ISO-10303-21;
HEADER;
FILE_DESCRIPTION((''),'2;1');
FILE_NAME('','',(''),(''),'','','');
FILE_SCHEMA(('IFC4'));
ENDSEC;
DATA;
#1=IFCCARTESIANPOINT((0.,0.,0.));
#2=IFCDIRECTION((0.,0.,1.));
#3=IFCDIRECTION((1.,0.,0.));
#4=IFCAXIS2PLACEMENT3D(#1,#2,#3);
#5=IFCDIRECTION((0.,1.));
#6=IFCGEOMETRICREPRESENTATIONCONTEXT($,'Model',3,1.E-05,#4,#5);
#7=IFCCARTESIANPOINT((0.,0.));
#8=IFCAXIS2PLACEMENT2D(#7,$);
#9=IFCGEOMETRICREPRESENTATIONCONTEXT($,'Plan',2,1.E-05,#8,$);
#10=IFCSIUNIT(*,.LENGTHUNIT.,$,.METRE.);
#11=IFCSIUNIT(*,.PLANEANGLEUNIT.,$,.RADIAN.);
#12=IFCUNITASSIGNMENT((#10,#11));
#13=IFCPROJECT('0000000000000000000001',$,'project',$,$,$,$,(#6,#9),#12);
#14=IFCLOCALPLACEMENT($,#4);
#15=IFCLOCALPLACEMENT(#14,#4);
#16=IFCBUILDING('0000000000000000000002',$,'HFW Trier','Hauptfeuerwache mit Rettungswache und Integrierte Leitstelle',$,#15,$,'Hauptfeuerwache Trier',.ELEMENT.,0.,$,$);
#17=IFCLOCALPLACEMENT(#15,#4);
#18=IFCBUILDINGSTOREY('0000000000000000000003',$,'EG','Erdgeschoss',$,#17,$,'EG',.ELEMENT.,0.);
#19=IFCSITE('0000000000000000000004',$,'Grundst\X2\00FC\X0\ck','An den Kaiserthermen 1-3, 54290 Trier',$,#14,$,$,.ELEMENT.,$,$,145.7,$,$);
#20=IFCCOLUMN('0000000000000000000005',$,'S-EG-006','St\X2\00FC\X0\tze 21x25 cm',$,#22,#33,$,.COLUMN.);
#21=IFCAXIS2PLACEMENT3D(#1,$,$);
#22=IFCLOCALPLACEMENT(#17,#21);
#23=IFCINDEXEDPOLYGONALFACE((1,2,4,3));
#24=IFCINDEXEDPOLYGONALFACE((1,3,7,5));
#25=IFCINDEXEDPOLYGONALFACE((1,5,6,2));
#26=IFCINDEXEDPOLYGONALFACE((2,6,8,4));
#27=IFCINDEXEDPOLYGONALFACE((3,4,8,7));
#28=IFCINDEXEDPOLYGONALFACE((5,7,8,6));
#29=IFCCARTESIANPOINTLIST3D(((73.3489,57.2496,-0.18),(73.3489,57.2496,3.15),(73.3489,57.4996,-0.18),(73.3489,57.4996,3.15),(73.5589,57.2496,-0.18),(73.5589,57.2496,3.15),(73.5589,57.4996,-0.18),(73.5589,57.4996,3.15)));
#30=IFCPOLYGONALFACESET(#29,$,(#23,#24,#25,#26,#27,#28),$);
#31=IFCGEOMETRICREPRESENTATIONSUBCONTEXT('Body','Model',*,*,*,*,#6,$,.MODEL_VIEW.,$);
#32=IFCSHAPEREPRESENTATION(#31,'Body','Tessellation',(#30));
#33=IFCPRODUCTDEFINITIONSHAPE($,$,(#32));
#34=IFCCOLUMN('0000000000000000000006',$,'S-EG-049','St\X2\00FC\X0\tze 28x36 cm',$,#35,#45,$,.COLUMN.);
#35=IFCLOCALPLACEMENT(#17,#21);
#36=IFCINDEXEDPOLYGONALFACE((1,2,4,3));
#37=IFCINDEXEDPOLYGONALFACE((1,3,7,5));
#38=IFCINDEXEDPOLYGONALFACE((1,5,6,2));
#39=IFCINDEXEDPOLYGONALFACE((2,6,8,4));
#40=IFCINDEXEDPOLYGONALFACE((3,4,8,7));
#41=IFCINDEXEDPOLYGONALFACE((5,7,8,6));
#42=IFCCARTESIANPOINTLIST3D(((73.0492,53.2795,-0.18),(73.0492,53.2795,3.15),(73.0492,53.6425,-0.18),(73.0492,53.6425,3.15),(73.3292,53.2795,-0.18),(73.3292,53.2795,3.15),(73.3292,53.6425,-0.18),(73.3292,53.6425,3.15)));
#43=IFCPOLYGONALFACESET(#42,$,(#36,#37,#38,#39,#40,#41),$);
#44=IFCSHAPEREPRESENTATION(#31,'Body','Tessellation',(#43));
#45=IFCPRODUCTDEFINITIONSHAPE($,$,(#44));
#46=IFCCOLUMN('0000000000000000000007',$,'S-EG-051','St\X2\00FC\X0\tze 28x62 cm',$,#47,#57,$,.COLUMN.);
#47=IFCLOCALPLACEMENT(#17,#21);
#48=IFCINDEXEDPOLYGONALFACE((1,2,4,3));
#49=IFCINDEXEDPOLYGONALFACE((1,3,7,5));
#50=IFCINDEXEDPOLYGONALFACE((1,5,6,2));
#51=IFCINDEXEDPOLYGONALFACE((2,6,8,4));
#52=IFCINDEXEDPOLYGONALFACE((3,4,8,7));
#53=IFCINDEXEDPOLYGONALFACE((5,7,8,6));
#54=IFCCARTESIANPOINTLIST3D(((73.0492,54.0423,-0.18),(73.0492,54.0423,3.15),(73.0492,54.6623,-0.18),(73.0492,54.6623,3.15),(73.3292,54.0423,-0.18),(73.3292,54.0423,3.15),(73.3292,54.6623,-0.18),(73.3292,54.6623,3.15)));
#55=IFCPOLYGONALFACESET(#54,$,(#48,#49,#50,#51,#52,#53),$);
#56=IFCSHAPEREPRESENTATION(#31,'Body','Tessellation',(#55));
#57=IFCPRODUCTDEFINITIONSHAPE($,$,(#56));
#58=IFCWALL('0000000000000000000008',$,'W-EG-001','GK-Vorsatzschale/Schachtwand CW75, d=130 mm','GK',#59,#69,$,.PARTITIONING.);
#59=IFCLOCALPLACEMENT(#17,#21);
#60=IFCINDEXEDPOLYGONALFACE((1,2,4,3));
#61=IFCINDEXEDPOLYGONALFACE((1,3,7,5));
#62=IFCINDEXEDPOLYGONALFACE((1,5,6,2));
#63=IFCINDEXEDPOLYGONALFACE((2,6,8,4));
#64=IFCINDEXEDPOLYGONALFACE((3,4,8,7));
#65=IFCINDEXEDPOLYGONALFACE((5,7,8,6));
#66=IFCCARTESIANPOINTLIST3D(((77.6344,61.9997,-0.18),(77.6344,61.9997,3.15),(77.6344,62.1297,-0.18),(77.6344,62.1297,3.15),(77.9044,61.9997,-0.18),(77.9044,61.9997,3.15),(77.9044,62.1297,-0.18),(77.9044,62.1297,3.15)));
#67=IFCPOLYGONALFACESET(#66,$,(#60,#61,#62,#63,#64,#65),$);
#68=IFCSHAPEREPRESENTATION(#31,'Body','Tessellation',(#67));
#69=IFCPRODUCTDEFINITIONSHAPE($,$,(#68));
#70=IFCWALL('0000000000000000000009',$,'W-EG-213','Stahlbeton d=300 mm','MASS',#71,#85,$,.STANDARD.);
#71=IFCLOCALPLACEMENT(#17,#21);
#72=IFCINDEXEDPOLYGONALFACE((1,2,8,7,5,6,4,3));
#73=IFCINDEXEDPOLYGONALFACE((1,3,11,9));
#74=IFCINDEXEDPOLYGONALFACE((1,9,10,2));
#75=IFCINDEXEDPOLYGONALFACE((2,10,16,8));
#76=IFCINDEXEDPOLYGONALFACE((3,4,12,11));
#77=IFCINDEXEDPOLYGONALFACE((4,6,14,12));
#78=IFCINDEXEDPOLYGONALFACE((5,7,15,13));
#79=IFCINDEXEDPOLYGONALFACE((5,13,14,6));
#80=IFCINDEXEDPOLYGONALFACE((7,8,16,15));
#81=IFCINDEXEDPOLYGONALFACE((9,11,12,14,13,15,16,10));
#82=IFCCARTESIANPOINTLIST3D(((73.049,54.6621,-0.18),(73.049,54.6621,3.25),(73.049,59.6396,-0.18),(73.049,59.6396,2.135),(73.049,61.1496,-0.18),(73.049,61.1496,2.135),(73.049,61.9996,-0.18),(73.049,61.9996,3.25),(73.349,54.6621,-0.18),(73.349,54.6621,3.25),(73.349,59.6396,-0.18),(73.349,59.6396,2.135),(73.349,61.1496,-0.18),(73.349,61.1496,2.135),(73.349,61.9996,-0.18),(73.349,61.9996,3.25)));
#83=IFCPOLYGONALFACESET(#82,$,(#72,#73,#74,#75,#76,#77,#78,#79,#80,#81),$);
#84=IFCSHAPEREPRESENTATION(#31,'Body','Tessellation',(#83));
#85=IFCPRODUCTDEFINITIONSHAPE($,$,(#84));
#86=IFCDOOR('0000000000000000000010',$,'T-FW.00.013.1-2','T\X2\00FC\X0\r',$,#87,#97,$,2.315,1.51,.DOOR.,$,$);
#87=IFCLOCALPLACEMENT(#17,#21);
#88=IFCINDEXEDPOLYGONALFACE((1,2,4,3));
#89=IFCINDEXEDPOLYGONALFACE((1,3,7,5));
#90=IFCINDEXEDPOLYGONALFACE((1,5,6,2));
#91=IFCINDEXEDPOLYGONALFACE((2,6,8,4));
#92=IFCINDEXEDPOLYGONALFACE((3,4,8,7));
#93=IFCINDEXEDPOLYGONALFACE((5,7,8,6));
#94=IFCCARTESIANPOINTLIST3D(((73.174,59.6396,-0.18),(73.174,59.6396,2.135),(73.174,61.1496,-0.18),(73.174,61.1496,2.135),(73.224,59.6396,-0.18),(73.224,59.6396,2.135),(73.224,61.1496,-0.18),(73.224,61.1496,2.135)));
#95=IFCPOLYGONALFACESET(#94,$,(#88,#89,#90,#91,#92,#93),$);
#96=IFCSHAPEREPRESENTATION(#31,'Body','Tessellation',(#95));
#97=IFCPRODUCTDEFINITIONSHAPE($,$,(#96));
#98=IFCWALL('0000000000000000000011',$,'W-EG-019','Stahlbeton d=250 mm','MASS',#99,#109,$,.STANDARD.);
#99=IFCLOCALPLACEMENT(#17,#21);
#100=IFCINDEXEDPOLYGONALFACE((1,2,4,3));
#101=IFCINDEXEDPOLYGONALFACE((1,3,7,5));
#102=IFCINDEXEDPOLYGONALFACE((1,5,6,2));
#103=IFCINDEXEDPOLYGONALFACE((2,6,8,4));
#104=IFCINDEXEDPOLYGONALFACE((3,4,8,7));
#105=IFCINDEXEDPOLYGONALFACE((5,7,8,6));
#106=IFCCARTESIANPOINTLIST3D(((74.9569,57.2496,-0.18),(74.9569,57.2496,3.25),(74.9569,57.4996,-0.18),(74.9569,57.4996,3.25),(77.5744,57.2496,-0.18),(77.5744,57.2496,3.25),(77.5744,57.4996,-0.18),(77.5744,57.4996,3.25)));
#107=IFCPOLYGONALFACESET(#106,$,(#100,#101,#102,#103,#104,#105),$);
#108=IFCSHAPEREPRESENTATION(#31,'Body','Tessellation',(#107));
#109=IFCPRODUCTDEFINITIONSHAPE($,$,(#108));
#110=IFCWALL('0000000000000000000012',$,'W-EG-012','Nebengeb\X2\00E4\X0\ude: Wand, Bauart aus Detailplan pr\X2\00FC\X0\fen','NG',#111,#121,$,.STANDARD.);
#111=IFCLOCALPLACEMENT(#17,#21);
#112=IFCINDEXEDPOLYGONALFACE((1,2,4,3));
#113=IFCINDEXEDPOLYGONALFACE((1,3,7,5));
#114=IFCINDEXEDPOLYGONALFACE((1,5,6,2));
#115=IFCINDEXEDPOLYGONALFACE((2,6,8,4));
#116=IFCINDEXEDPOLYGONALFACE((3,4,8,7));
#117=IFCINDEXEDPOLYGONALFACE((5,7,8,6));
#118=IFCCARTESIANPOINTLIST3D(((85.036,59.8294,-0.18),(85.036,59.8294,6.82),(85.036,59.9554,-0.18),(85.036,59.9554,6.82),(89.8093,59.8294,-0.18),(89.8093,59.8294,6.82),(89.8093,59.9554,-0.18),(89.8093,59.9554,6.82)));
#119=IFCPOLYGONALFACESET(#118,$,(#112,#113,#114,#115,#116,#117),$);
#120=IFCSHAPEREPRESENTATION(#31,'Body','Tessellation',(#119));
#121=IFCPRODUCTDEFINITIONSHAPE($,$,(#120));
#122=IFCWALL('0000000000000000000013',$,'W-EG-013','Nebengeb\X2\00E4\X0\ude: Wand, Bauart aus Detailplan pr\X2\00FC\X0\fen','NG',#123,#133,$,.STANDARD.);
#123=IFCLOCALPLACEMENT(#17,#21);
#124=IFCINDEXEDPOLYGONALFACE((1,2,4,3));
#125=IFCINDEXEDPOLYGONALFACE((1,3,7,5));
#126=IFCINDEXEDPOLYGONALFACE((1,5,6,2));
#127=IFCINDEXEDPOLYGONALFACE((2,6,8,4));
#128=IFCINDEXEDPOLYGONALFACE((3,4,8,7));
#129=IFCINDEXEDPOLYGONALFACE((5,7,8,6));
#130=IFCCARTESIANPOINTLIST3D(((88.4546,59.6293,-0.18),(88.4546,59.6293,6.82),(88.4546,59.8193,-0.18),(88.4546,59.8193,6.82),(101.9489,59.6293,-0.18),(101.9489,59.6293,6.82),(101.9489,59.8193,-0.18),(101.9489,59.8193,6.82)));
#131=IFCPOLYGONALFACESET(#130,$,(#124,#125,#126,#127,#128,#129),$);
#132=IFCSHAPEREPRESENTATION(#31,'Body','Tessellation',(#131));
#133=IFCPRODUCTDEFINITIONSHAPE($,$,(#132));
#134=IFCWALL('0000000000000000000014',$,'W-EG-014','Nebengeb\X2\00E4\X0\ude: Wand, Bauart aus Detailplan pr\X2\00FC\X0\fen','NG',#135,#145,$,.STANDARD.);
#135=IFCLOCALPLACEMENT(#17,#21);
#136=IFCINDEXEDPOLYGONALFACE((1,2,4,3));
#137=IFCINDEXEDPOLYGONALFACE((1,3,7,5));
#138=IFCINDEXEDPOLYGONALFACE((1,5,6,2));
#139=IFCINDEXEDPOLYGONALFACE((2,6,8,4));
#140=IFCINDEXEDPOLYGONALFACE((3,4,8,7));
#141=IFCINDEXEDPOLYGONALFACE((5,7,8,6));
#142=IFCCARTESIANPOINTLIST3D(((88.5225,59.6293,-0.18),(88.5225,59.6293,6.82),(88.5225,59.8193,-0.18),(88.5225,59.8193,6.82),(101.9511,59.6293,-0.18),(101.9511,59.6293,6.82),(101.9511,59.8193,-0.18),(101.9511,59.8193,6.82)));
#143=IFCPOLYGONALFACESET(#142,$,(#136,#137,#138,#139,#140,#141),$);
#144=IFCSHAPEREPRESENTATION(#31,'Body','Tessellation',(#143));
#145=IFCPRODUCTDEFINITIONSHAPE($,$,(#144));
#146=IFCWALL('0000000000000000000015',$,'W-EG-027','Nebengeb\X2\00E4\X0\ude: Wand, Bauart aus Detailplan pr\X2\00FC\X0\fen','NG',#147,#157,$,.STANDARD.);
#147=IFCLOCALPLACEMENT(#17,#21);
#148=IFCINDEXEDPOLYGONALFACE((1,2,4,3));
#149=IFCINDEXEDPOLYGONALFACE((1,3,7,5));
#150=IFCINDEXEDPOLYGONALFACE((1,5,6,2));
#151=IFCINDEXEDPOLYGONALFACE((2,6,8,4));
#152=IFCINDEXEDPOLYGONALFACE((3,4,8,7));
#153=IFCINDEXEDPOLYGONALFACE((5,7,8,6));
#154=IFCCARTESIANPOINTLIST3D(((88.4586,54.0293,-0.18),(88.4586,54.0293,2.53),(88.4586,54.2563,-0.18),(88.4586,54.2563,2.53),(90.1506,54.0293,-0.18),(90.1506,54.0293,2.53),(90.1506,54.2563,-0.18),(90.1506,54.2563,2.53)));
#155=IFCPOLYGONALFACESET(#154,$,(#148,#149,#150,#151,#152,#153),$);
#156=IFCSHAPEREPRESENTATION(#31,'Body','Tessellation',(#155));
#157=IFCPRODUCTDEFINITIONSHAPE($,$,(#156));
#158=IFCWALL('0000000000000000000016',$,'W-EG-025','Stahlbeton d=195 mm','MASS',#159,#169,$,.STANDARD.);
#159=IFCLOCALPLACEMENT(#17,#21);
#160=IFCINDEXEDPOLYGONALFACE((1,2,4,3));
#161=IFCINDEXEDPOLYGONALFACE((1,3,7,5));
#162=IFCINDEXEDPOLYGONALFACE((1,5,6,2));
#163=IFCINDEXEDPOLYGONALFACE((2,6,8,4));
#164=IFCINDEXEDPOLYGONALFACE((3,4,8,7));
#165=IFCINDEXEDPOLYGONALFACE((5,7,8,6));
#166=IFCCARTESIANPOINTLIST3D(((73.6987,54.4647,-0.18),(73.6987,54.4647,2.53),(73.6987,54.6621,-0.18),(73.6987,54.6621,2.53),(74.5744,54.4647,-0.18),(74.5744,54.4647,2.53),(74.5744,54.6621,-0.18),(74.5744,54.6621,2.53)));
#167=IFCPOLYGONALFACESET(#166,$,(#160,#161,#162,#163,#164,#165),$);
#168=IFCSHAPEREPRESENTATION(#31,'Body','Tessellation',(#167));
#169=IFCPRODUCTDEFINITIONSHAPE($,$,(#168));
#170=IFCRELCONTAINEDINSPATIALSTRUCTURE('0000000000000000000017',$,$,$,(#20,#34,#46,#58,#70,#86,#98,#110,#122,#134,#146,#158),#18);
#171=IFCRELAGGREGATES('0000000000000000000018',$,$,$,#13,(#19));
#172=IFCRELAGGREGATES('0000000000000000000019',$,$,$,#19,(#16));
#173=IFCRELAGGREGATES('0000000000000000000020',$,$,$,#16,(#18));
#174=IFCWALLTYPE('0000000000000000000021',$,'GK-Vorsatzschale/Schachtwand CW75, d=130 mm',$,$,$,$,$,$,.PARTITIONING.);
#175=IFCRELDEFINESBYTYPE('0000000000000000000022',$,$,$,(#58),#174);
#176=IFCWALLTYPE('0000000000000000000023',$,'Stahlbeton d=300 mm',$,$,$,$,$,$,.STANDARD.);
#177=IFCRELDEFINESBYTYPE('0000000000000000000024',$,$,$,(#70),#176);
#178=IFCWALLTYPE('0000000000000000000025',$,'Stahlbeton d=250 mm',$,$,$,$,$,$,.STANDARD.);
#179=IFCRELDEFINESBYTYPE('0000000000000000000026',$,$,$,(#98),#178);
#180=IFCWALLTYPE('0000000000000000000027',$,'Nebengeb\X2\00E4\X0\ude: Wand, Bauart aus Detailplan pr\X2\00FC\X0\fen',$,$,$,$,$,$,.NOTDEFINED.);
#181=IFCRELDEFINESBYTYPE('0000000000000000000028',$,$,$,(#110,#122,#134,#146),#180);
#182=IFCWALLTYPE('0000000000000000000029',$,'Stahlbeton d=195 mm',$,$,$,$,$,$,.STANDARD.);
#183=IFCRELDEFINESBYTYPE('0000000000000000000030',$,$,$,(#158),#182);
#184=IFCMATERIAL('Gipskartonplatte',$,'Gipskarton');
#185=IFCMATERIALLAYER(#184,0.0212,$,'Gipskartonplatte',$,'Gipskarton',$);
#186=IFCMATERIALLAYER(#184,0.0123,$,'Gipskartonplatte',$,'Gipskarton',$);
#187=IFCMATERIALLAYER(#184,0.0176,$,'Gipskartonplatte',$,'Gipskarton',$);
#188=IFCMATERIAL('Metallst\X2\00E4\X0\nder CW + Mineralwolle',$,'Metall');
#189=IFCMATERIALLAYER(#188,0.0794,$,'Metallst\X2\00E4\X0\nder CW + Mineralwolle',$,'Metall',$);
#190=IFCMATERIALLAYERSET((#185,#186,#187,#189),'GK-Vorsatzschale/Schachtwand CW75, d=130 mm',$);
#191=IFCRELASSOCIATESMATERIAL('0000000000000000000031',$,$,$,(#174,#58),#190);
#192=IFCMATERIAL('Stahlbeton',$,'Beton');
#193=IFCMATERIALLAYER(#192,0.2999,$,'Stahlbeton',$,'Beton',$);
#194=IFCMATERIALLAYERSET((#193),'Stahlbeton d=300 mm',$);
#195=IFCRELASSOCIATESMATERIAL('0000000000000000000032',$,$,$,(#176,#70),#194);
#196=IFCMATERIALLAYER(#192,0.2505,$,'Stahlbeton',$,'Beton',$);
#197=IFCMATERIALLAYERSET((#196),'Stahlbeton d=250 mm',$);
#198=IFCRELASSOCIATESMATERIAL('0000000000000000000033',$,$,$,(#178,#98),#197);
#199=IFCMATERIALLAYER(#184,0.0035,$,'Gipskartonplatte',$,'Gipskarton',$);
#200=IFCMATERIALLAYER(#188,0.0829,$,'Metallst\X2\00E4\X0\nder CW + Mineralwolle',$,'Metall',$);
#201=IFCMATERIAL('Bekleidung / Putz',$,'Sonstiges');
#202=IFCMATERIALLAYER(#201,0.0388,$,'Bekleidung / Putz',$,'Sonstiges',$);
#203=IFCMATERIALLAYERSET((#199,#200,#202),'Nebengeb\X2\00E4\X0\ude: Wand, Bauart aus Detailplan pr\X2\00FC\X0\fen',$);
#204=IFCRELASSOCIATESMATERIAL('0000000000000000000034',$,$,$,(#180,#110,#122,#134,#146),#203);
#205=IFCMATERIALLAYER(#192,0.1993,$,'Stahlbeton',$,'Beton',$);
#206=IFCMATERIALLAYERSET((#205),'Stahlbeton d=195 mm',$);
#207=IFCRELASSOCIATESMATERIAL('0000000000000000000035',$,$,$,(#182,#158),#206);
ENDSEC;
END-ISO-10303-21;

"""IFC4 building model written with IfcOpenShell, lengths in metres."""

from ifc_helpers import new_model, si_unit, direction, frame, frame_2d, origin_with_axes, origin_2d, place, context, subcontext, project, spatial, rectangle, extrude, material, layer, layer_set, layer_usage, type_object, element, fill, save


model = new_model("IFC4")

# Units and contexts
model_context = context("Model", 3, precision=1e-05, world=origin_with_axes(), true_north=direction((0.0, 1.0)))
plan_context = context("Plan", 2, precision=1e-05, world=origin_2d())
body_context = subcontext(model_context, "Body", "Model", "MODEL_VIEW")
ifc_project = project(units=[si_unit("LENGTHUNIT", "METRE"), si_unit("PLANEANGLEUNIT", "RADIAN")], contexts=[model_context, plan_context])

# Site, building, storey
site_placement = place(None, origin_with_axes())
site = spatial("IfcSite", under=ifc_project, at=site_placement, Name="Grundstück", Description="An den Kaiserthermen 1-3, 54290 Trier", CompositionType="ELEMENT", RefElevation=145.7)
building_placement = place(site_placement, origin_with_axes())
building = spatial("IfcBuilding", under=site, at=building_placement, Name="HFW Trier", Description="Hauptfeuerwache mit Rettungswache und Integrierte Leitstelle", LongName="Hauptfeuerwache Trier", CompositionType="ELEMENT", ElevationOfRefHeight=0.0)
storey_placement = place(building_placement, origin_with_axes())
storey = spatial("IfcBuildingStorey", under=building, at=storey_placement, Name="EG", Description="Erdgeschoss", LongName="EG", CompositionType="ELEMENT", Elevation=0.0)

# Columns
column_1_placement = place(storey_placement, frame((73.3489, 57.3746, -0.18), z_axis=(0.0, 0.0, 1.0), x_axis=(1.0, 0.0, 0.0)))
element("IfcColumn", 1, at=column_1_placement, inside=storey, Name="S-EG-006", Description="Stütze 21x25 cm", PredefinedType="COLUMN", context=body_context, shape_type="SweptSolid", body=[
    extrude(rectangle(XDim=0.21, YDim=0.25, at=frame_2d((0.105, 0.0))), origin_with_axes(), (0.0, 0.0, 1.0), 3.33),
])
column_2_placement = place(storey_placement, frame((73.0492, 53.461, -0.18), z_axis=(0.0, 0.0, 1.0), x_axis=(1.0, 0.0, 0.0)))
element("IfcColumn", 2, at=column_2_placement, inside=storey, Name="S-EG-049", Description="Stütze 28x36 cm", PredefinedType="COLUMN", context=body_context, shape_type="SweptSolid", body=[
    extrude(rectangle(XDim=0.28, YDim=0.363, at=frame_2d((0.14, 0.0))), origin_with_axes(), (0.0, 0.0, 1.0), 3.33),
])
column_3_placement = place(storey_placement, frame((73.0492, 54.3523, -0.18), z_axis=(0.0, 0.0, 1.0), x_axis=(1.0, 0.0, 0.0)))
element("IfcColumn", 3, at=column_3_placement, inside=storey, Name="S-EG-051", Description="Stütze 28x62 cm", PredefinedType="COLUMN", context=body_context, shape_type="SweptSolid", body=[
    extrude(rectangle(XDim=0.28, YDim=0.62, at=frame_2d((0.14, 0.0))), origin_with_axes(), (0.0, 0.0, 1.0), 3.33),
])

# Wall
ifc_material_1 = material(Name="Gipskartonplatte", Category="Gipskarton")
ifc_layer_1 = layer(ifc_material_1, 0.0212, Name="Gipskartonplatte", Category="Gipskarton")
ifc_layer_2 = layer(ifc_material_1, 0.0123, Name="Gipskartonplatte", Category="Gipskarton")
ifc_layer_3 = layer(ifc_material_1, 0.0176, Name="Gipskartonplatte", Category="Gipskarton")
ifc_material_2 = material(Name="Metallständer CW + Mineralwolle", Category="Metall")
ifc_layer_4 = layer(ifc_material_2, 0.0794, Name="Metallständer CW + Mineralwolle", Category="Metall")
ifc_layer_set_1 = layer_set([ifc_layer_1, ifc_layer_2, ifc_layer_3, ifc_layer_4], Name="GK-Vorsatzschale/Schachtwand CW75, d=130 mm")
ifc_layer_usage_1 = layer_usage(ifc_layer_set_1, "AXIS2", "POSITIVE", -0.065)
wall_type_1 = type_object("IfcWallType", Name="GK-Vorsatzschale/Schachtwand CW75, d=130 mm", PredefinedType="PARTITIONING", material=ifc_layer_set_1)
wall_1_placement = place(storey_placement, frame((77.6344, 62.0647, -0.18), z_axis=(0.0, 0.0, 1.0), x_axis=(1.0, 0.0, 0.0)))
element("IfcWall", 4, at=wall_1_placement, inside=storey, type_object=wall_type_1, material=ifc_layer_usage_1, Name="W-EG-001", Description="GK-Vorsatzschale/Schachtwand CW75, d=130 mm", ObjectType="GK", PredefinedType="PARTITIONING", context=body_context, shape_type="SweptSolid", body=[
    extrude(rectangle(XDim=0.27, YDim=0.13, at=frame_2d((0.135, 0.0))), origin_with_axes(), (0.0, 0.0, 1.0), 3.33),
])

# Wall, opening, door
ifc_material_3 = material(Name="Stahlbeton", Category="Beton")
ifc_layer_5 = layer(ifc_material_3, 0.2999, Name="Stahlbeton", Category="Beton")
ifc_layer_set_2 = layer_set([ifc_layer_5], Name="Stahlbeton d=300 mm")
ifc_layer_usage_2 = layer_usage(ifc_layer_set_2, "AXIS2", "POSITIVE", -0.15)
wall_type_2 = type_object("IfcWallType", Name="Stahlbeton d=300 mm", PredefinedType="STANDARD", material=ifc_layer_set_2)
wall_2_placement = place(storey_placement, frame((73.199, 61.9996, -0.18), z_axis=(0.0, 0.0, 1.0), x_axis=(0.0, -1.0, 0.0)))
wall_2 = element("IfcWall", 5, at=wall_2_placement, inside=storey, type_object=wall_type_2, material=ifc_layer_usage_2, Name="W-EG-213", Description="Stahlbeton d=300 mm", ObjectType="MASS", PredefinedType="STANDARD", context=body_context, shape_type="SweptSolid", body=[
    extrude(rectangle(XDim=7.3375, YDim=0.3, at=frame_2d((3.6687, 0.0))), origin_with_axes(), (0.0, 0.0, 1.0), 3.43),
])
opening_1_placement = place(wall_2_placement, frame((0.85, 0.0, 0.0), z_axis=(0.0, 0.0, 1.0), x_axis=(1.0, 0.0, 0.0)))
opening_1 = element("IfcOpeningElement", 6, at=opening_1_placement, cuts=wall_2, PredefinedType="OPENING", context=body_context, shape_type="SweptSolid", body=[
    extrude(rectangle(XDim=1.51, YDim=0.4, at=frame_2d((0.755, 0.0))), origin_with_axes(), (0.0, 0.0, 1.0), 2.315),
])
door_1_placement = place(wall_2_placement, frame((0.85, 0.0, 0.0), z_axis=(0.0, 0.0, 1.0), x_axis=(1.0, 0.0, 0.0)))
door_1 = element("IfcDoor", 7, at=door_1_placement, inside=storey, Name="T-FW.00.013.1-2", Description="Tür", OverallHeight=2.315, OverallWidth=1.51, PredefinedType="DOOR", context=body_context, shape_type="SweptSolid", body=[
    extrude(rectangle(XDim=1.51, YDim=0.05, at=frame_2d((0.755, 0.0))), origin_with_axes(), (0.0, 0.0, 1.0), 2.315),
])
fill(opening_1, door_1)

# Walls
ifc_layer_6 = layer(ifc_material_3, 0.2505, Name="Stahlbeton", Category="Beton")
ifc_layer_set_3 = layer_set([ifc_layer_6], Name="Stahlbeton d=250 mm")
ifc_layer_usage_3 = layer_usage(ifc_layer_set_3, "AXIS2", "POSITIVE", -0.125)
wall_type_3 = type_object("IfcWallType", Name="Stahlbeton d=250 mm", PredefinedType="STANDARD", material=ifc_layer_set_3)
wall_3_placement = place(storey_placement, frame((74.9569, 57.3746, -0.18), z_axis=(0.0, 0.0, 1.0), x_axis=(1.0, 0.0, 0.0)))
element("IfcWall", 8, at=wall_3_placement, inside=storey, type_object=wall_type_3, material=ifc_layer_usage_3, Name="W-EG-019", Description="Stahlbeton d=250 mm", ObjectType="MASS", PredefinedType="STANDARD", context=body_context, shape_type="SweptSolid", body=[
    extrude(rectangle(XDim=2.6175, YDim=0.25, at=frame_2d((1.3087, 0.0))), origin_with_axes(), (0.0, 0.0, 1.0), 3.43),
])
ifc_layer_7 = layer(ifc_material_1, 0.0035, Name="Gipskartonplatte", Category="Gipskarton")
ifc_layer_8 = layer(ifc_material_2, 0.0829, Name="Metallständer CW + Mineralwolle", Category="Metall")
ifc_material_4 = material(Name="Bekleidung / Putz", Category="Sonstiges")
ifc_layer_9 = layer(ifc_material_4, 0.0388, Name="Bekleidung / Putz", Category="Sonstiges")
ifc_layer_set_4 = layer_set([ifc_layer_7, ifc_layer_8, ifc_layer_9], Name="Nebengebäude: Wand, Bauart aus Detailplan prüfen")
ifc_layer_usage_4 = layer_usage(ifc_layer_set_4, "AXIS2", "POSITIVE", -0.063)
wall_type_4 = type_object("IfcWallType", Name="Nebengebäude: Wand, Bauart aus Detailplan prüfen", PredefinedType="NOTDEFINED", material=ifc_layer_set_4)
wall_4_placement = place(storey_placement, frame((85.036, 59.8924, -0.18), z_axis=(0.0, 0.0, 1.0), x_axis=(1.0, 0.0, 0.0)))
element("IfcWall", 9, at=wall_4_placement, inside=storey, type_object=wall_type_4, material=ifc_layer_usage_4, Name="W-EG-012", Description="Nebengebäude: Wand, Bauart aus Detailplan prüfen", ObjectType="NG", PredefinedType="STANDARD", context=body_context, shape_type="SweptSolid", body=[
    extrude(rectangle(XDim=4.7733, YDim=0.1261, at=frame_2d((2.3866, 0.0))), origin_with_axes(), (0.0, 0.0, 1.0), 7.0),
])
ifc_layer_usage_5 = layer_usage(ifc_layer_set_4, "AXIS2", "POSITIVE", -0.095)
wall_5_placement = place(storey_placement, frame((88.4546, 59.7243, -0.18), z_axis=(0.0, 0.0, 1.0), x_axis=(1.0, 0.0, 0.0)))
element("IfcWall", 10, at=wall_5_placement, inside=storey, type_object=wall_type_4, material=ifc_layer_usage_5, Name="W-EG-013", Description="Nebengebäude: Wand, Bauart aus Detailplan prüfen", ObjectType="NG", PredefinedType="STANDARD", context=body_context, shape_type="SweptSolid", body=[
    extrude(rectangle(XDim=13.4943, YDim=0.19, at=frame_2d((6.7471, 0.0))), origin_with_axes(), (0.0, 0.0, 1.0), 7.0),
])
ifc_layer_usage_6 = layer_usage(ifc_layer_set_4, "AXIS2", "POSITIVE", -0.095)
wall_6_placement = place(storey_placement, frame((88.5225, 59.7243, -0.18), z_axis=(0.0, 0.0, 1.0), x_axis=(1.0, 0.0, 0.0)))
element("IfcWall", 11, at=wall_6_placement, inside=storey, type_object=wall_type_4, material=ifc_layer_usage_6, Name="W-EG-014", Description="Nebengebäude: Wand, Bauart aus Detailplan prüfen", ObjectType="NG", PredefinedType="STANDARD", context=body_context, shape_type="SweptSolid", body=[
    extrude(rectangle(XDim=13.4286, YDim=0.19, at=frame_2d((6.7143, 0.0))), origin_with_axes(), (0.0, 0.0, 1.0), 7.0),
])
ifc_layer_usage_7 = layer_usage(ifc_layer_set_4, "AXIS2", "POSITIVE", -0.1135)
wall_7_placement = place(storey_placement, frame((88.4586, 54.1428, -0.18), z_axis=(0.0, 0.0, 1.0), x_axis=(1.0, 0.0, 0.0)))
element("IfcWall", 12, at=wall_7_placement, inside=storey, type_object=wall_type_4, material=ifc_layer_usage_7, Name="W-EG-027", Description="Nebengebäude: Wand, Bauart aus Detailplan prüfen", ObjectType="NG", PredefinedType="STANDARD", context=body_context, shape_type="SweptSolid", body=[
    extrude(rectangle(XDim=1.692, YDim=0.227, at=frame_2d((0.846, 0.0))), origin_with_axes(), (0.0, 0.0, 1.0), 2.71),
])
ifc_layer_10 = layer(ifc_material_3, 0.1993, Name="Stahlbeton", Category="Beton")
ifc_layer_set_5 = layer_set([ifc_layer_10], Name="Stahlbeton d=195 mm")
ifc_layer_usage_8 = layer_usage(ifc_layer_set_5, "AXIS2", "POSITIVE", -0.0987)
wall_type_5 = type_object("IfcWallType", Name="Stahlbeton d=195 mm", PredefinedType="STANDARD", material=ifc_layer_set_5)
wall_8_placement = place(storey_placement, frame((73.6987, 54.5634, -0.18), z_axis=(0.0, 0.0, 1.0), x_axis=(1.0, 0.0, 0.0)))
element("IfcWall", 13, at=wall_8_placement, inside=storey, type_object=wall_type_5, material=ifc_layer_usage_8, Name="W-EG-025", Description="Stahlbeton d=195 mm", ObjectType="MASS", PredefinedType="STANDARD", context=body_context, shape_type="SweptSolid", body=[
    extrude(rectangle(XDim=0.8757, YDim=0.1974, at=frame_2d((0.4378, 0.0))), origin_with_axes(), (0.0, 0.0, 1.0), 2.71),
])

save(model, "model.ifc")
